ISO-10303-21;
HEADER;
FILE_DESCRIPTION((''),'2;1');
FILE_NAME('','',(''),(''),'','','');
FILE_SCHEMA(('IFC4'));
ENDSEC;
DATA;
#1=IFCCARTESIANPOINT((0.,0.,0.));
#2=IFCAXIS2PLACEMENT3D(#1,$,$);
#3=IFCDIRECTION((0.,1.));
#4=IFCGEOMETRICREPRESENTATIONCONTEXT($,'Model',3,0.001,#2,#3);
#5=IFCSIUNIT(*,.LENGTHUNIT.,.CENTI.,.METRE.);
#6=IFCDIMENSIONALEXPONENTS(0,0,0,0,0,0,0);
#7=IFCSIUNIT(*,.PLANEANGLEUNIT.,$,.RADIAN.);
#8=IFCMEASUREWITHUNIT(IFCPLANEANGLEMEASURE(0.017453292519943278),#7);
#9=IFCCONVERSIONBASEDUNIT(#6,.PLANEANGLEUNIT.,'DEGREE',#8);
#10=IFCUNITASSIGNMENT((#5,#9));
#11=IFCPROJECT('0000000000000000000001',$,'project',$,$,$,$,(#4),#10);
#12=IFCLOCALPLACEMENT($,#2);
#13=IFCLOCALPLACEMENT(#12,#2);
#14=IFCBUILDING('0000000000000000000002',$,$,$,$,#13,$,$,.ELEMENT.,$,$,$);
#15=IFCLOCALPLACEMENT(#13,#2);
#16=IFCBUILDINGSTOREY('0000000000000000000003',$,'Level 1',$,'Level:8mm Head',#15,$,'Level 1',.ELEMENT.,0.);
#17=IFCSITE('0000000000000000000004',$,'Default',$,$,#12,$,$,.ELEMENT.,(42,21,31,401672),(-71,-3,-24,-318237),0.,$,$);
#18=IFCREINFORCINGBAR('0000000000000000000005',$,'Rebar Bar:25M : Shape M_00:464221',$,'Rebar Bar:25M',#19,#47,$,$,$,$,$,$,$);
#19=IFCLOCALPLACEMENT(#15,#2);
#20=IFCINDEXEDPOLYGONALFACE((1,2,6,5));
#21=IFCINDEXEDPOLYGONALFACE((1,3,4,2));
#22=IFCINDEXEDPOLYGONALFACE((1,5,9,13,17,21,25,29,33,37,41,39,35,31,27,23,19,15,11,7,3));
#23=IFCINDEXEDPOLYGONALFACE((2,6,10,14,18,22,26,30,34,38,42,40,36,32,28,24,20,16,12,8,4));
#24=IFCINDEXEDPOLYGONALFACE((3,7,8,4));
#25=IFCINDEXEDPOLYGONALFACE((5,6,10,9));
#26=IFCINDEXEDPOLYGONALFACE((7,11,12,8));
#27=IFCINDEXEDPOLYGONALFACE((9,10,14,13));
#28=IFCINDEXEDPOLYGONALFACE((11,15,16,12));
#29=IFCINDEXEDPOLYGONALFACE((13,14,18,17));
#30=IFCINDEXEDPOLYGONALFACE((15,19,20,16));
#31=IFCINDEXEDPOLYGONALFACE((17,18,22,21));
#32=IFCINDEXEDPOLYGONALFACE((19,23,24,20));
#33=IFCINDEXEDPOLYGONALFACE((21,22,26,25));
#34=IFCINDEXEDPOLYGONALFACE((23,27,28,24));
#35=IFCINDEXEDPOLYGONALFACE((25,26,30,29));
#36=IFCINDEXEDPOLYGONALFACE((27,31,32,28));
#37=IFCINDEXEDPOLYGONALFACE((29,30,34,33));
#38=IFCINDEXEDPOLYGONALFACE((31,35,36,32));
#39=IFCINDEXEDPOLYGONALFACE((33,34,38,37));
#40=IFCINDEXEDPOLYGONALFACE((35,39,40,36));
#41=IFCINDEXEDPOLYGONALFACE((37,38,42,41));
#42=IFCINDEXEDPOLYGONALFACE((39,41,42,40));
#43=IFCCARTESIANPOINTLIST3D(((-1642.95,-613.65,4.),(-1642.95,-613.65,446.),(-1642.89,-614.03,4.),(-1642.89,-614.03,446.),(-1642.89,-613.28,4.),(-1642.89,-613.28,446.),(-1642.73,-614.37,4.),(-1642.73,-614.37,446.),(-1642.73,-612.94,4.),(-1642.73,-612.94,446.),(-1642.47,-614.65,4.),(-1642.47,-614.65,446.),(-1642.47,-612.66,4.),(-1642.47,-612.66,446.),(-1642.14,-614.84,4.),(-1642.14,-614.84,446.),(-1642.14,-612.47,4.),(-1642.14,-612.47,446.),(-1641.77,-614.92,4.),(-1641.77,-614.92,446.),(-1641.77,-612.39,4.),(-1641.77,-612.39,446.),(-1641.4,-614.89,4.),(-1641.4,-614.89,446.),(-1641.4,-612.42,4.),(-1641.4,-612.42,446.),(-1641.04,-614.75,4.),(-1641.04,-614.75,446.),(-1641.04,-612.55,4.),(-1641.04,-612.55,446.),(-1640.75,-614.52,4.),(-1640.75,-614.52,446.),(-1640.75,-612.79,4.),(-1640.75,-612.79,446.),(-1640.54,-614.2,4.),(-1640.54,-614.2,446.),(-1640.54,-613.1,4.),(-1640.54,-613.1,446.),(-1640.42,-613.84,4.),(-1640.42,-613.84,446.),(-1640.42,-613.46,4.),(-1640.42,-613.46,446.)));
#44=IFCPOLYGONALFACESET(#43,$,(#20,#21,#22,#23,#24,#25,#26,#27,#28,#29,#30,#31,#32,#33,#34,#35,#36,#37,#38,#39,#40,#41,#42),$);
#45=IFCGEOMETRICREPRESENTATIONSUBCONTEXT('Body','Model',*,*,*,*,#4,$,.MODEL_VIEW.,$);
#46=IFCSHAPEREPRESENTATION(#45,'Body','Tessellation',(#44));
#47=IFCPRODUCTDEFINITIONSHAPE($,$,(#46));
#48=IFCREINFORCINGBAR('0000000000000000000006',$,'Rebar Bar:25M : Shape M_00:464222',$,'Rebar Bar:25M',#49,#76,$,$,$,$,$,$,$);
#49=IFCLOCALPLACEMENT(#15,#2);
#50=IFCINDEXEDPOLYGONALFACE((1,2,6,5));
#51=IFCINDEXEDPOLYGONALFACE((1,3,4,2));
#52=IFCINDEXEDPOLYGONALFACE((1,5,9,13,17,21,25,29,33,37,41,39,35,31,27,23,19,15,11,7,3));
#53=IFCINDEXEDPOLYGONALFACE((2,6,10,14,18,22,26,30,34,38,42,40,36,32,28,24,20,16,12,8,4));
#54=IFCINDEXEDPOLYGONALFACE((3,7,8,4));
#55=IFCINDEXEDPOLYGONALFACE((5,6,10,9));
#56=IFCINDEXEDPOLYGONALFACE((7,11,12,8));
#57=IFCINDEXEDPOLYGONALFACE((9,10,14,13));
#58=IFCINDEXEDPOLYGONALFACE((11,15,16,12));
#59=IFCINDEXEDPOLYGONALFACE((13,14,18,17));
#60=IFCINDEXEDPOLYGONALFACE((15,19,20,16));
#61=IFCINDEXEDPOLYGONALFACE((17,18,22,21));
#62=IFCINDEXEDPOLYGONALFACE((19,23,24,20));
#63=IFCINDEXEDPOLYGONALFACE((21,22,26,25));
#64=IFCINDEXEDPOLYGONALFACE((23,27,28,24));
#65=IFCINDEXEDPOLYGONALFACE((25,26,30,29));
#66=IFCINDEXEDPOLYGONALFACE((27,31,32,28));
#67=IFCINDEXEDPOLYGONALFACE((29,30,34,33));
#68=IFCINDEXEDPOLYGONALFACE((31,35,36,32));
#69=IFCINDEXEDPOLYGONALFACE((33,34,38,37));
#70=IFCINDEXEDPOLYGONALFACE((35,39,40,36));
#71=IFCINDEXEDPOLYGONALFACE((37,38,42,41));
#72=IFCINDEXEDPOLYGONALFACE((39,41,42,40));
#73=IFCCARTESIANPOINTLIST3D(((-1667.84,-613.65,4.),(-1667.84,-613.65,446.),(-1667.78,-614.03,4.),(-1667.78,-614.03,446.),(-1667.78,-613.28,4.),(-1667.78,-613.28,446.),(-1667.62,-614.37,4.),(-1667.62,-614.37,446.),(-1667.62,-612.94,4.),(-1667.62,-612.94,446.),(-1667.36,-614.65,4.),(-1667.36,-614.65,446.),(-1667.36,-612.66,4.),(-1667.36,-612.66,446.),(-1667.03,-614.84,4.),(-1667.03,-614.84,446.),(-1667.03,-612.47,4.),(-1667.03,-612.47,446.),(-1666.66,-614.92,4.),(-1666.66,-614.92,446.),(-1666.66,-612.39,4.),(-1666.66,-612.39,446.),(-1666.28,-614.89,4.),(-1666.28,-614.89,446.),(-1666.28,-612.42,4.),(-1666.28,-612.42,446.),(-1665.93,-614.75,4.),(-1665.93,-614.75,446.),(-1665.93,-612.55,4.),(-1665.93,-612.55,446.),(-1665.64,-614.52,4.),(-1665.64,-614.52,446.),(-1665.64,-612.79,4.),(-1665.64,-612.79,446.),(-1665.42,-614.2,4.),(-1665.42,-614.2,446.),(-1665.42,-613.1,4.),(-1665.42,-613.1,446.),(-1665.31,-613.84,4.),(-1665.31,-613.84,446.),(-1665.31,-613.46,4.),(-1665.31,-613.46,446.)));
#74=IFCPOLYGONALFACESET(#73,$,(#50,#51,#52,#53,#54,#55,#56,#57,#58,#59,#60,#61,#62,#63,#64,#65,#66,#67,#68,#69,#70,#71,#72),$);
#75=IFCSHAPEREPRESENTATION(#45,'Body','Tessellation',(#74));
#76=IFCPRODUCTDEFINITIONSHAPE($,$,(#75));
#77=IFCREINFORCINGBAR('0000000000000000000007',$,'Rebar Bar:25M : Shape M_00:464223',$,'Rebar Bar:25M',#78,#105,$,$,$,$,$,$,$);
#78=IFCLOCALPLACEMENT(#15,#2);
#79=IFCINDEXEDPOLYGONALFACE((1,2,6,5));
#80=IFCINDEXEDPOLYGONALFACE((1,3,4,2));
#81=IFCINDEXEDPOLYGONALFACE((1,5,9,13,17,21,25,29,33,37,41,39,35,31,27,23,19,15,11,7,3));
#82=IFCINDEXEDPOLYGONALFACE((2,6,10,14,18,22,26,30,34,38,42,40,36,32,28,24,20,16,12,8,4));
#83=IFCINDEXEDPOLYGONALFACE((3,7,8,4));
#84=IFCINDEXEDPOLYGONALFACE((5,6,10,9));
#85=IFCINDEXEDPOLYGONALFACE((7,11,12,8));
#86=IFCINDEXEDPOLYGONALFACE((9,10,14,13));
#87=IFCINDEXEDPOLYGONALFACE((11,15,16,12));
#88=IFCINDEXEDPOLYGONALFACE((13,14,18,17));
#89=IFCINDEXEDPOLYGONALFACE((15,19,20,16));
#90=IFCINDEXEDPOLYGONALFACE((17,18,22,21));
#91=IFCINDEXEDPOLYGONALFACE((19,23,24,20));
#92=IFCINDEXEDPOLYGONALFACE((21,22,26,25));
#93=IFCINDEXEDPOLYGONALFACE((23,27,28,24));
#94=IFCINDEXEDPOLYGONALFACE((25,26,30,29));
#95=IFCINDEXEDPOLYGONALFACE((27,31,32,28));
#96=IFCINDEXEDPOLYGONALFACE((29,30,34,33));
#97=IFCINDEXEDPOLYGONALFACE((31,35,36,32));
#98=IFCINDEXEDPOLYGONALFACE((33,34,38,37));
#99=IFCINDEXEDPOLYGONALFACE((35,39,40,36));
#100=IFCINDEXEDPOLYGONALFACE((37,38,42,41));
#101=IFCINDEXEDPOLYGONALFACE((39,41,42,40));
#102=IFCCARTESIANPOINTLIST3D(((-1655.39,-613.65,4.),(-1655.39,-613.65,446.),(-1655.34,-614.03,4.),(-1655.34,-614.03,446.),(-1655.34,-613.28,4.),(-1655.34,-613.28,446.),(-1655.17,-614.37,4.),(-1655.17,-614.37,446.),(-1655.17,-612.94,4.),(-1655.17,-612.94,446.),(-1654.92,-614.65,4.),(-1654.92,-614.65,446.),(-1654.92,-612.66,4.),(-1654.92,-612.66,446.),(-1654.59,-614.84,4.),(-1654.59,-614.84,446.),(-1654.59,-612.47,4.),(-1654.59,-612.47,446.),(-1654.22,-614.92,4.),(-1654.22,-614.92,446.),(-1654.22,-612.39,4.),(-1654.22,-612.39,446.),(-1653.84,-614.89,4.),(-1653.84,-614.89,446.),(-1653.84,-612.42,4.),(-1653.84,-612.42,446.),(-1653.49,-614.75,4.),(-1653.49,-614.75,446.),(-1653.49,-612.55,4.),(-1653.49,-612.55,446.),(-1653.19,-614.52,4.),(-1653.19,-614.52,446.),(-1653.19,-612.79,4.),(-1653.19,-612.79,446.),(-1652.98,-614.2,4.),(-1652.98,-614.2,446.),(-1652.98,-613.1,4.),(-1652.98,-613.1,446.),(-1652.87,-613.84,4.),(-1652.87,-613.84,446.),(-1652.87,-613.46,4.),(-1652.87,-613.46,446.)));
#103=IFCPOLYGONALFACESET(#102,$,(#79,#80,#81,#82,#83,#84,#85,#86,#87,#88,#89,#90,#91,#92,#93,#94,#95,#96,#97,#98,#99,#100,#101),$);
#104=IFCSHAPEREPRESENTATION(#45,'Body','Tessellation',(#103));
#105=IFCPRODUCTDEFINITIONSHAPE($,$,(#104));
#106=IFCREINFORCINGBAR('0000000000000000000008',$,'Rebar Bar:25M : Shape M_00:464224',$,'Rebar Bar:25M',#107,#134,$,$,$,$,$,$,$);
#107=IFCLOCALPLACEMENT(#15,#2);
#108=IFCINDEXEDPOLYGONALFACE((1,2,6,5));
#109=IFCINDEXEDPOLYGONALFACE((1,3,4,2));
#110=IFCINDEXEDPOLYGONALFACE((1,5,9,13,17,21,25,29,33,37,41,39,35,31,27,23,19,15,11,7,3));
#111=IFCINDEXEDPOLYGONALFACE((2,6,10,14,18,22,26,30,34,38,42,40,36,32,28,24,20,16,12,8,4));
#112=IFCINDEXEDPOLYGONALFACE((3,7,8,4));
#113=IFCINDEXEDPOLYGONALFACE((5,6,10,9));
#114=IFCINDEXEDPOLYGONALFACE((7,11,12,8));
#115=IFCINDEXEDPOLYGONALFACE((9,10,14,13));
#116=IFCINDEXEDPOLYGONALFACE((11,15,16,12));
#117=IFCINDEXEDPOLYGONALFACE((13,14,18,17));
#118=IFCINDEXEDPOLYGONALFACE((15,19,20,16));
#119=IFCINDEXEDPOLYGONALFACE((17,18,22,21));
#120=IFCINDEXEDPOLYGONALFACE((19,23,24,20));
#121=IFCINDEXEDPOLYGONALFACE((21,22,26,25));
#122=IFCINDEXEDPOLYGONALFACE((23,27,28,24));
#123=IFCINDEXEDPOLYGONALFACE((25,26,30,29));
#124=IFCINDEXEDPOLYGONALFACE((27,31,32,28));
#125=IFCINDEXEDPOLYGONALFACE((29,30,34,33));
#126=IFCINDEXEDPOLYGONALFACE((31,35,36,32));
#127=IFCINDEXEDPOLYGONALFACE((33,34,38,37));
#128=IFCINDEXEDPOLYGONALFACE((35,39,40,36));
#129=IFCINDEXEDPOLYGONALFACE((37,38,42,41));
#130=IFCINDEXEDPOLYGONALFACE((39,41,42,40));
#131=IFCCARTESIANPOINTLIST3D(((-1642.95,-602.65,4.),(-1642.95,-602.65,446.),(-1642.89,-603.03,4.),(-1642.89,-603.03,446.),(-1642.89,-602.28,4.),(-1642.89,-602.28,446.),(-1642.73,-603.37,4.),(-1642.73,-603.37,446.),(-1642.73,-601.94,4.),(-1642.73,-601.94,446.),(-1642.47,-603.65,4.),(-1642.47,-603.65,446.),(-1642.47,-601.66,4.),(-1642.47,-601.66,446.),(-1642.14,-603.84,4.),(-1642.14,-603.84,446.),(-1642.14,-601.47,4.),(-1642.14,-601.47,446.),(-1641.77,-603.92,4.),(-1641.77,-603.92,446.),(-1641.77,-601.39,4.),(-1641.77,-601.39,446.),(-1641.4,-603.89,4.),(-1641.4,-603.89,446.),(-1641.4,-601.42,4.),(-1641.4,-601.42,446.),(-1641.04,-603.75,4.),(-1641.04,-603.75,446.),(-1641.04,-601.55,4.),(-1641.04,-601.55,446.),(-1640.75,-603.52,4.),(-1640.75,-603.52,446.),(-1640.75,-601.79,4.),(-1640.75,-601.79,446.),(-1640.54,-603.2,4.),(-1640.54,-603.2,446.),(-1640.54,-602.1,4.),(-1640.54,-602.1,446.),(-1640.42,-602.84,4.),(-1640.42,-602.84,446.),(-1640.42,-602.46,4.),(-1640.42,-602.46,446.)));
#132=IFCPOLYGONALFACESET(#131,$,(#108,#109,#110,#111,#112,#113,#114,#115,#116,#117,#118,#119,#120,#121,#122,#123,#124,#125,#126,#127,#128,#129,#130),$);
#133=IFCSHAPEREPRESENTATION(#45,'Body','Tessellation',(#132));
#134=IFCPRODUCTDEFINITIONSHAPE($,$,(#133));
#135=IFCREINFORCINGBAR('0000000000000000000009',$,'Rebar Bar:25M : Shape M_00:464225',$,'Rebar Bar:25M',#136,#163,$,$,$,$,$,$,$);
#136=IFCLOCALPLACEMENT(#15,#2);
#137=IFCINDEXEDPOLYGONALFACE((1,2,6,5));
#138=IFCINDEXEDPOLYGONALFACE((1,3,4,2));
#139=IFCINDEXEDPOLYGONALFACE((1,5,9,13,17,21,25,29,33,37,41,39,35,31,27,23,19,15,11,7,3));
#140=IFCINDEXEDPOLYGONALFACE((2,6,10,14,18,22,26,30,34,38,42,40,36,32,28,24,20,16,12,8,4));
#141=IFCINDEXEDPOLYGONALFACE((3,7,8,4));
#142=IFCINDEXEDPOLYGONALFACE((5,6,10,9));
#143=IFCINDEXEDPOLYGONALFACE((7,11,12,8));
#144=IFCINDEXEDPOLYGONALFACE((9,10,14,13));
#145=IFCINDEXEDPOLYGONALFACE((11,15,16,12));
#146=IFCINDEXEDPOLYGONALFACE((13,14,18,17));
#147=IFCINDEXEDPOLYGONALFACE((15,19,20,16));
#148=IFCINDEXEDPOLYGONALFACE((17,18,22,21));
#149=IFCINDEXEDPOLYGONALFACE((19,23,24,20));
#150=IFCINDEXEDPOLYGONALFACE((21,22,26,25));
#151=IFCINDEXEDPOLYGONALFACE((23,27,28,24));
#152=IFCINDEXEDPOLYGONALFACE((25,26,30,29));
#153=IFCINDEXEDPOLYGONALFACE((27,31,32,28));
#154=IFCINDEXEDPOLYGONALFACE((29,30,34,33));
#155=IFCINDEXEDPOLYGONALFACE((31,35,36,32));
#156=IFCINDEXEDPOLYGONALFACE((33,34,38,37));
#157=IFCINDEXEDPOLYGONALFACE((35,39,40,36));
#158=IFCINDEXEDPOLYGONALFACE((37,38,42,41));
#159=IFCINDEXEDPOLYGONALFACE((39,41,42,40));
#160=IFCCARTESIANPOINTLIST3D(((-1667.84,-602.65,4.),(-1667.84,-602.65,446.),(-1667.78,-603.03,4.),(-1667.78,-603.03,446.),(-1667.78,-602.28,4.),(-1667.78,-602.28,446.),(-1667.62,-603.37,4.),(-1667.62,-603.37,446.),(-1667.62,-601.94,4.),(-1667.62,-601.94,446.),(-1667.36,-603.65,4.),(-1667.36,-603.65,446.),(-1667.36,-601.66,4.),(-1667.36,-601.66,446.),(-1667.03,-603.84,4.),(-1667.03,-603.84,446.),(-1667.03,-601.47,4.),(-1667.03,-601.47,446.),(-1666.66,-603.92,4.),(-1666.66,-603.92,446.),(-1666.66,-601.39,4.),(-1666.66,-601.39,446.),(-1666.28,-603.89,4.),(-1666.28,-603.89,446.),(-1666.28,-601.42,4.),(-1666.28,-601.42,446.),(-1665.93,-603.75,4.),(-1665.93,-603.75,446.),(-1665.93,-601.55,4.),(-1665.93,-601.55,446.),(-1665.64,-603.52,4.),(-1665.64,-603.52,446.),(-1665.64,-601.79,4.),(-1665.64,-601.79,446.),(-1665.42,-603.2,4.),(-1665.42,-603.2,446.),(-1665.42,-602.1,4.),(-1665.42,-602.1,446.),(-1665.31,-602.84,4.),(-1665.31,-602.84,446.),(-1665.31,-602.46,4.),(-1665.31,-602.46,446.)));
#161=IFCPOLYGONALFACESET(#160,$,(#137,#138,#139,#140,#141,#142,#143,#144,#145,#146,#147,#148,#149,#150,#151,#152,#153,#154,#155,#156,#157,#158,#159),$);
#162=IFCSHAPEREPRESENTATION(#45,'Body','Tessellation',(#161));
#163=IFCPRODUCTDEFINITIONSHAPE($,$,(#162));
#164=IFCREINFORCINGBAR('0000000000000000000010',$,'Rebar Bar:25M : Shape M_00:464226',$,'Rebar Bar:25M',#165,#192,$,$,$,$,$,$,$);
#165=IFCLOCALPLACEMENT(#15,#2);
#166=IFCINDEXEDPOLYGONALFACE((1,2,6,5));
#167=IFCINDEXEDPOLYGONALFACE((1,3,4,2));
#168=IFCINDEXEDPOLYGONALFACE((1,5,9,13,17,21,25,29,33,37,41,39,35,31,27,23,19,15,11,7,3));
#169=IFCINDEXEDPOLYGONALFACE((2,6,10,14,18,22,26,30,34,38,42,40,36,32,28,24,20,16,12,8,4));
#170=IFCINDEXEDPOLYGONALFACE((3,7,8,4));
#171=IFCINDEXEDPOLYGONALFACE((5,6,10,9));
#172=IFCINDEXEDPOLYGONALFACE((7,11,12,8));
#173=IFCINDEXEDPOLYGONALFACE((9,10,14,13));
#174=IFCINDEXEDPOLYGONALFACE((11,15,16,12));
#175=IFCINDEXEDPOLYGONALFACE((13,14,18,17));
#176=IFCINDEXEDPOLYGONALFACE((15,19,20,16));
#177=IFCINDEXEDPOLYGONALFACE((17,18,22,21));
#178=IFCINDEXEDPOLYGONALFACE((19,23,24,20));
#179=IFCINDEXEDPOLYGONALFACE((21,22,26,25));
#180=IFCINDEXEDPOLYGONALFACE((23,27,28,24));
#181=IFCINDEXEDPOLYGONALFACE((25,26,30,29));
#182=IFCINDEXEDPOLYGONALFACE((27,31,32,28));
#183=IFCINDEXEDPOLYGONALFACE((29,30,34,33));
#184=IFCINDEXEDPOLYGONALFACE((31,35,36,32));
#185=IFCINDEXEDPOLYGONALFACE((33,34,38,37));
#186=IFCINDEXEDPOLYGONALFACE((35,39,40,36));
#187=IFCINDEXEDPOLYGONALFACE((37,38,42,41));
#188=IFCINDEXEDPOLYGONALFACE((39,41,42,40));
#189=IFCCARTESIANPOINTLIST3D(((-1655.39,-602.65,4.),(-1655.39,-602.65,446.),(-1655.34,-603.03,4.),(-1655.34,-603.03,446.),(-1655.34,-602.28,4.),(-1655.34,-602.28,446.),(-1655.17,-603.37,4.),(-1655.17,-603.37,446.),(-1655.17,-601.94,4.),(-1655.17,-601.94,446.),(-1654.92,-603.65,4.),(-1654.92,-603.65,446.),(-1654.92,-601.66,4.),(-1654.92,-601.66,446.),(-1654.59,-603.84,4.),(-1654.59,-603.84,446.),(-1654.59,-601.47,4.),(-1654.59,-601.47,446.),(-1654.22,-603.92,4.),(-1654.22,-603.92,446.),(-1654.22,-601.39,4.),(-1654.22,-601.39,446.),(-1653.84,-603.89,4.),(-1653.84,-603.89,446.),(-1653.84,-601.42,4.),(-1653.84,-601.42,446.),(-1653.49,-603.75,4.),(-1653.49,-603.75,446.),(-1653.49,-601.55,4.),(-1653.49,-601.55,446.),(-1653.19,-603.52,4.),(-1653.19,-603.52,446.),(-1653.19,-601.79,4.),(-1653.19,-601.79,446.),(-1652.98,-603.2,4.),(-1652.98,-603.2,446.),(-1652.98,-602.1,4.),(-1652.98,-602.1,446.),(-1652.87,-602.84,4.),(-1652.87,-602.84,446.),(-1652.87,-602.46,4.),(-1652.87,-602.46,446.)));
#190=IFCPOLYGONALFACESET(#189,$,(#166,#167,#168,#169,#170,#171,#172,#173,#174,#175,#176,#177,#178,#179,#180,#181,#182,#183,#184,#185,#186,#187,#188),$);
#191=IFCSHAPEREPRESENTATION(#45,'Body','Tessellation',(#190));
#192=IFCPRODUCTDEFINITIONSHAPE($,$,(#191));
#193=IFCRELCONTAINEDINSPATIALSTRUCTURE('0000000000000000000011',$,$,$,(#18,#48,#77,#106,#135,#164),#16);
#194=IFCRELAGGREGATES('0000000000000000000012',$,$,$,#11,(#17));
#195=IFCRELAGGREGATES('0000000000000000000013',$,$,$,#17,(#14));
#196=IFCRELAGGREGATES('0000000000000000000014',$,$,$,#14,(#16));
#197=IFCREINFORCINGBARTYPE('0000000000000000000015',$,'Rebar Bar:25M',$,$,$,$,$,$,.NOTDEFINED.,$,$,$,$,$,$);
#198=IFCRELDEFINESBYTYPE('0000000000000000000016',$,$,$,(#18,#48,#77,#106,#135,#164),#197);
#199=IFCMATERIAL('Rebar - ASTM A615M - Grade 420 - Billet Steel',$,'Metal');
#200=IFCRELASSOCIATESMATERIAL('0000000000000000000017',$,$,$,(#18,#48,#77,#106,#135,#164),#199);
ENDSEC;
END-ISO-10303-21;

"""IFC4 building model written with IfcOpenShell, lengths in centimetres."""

from ifc_helpers import new_model, entity, si_unit, converted_unit, direction, origin, place, context, subcontext, project, spatial, material, type_object, element, save


model = new_model("IFC4")

# Units and contexts
model_context = context("Model", 3, precision=0.001, world=origin(), true_north=direction((0.0, 1.0)))
body_context = subcontext(model_context, "Body", "Model", "MODEL_VIEW")
ifc_project = project(units=[si_unit("LENGTHUNIT", "METRE", prefix="CENTI"), converted_unit("PLANEANGLEUNIT", "DEGREE", entity("IfcPlaneAngleMeasure", 0.017453292519943278), si_unit("PLANEANGLEUNIT", "RADIAN"), dimensions=[0, 0, 0, 0, 0, 0, 0])], contexts=[model_context])

# Site, building, storey
site_placement = place(None, origin())
site = spatial("IfcSite", under=ifc_project, at=site_placement, Name="Default", CompositionType="ELEMENT", RefLatitude=(42, 21, 31, 401672), RefLongitude=(-71, -3, -24, -318237), RefElevation=0.0)
building_placement = place(site_placement, origin())
building = spatial("IfcBuilding", under=site, at=building_placement, CompositionType="ELEMENT")
storey_placement = place(building_placement, origin())
storey = spatial("IfcBuildingStorey", under=building, at=storey_placement, Name="Level 1", ObjectType="Level:8mm Head", LongName="Level 1", CompositionType="ELEMENT", Elevation=0.0)

# Reinforcing bars
ifc_material = material(Name="Rebar - ASTM A615M - Grade 420 - Billet Steel", Category="Metal")
reinforcing_bar_type_1 = type_object("IfcReinforcingBarType", Name="Rebar Bar:25M", PredefinedType="NOTDEFINED")
reinforcing_bar_1_placement = place(storey_placement, origin())
element("IfcReinforcingBar", 1, at=reinforcing_bar_1_placement, inside=storey, type_object=reinforcing_bar_type_1, material=ifc_material, Name="Rebar Bar:25M : Shape M_00:464221", ObjectType="Rebar Bar:25M", context=body_context, shape_type="AdvancedSweptSolid", body=[
    entity("IfcSweptDiskSolid", entity("IfcIndexedPolyCurve", entity("IfcCartesianPointList3D", [[-1641.68, -613.65, 446.0], [-1641.68, -613.65, 4.0]]), None, False), 1.27, None, 0.0, 1.0),
])
reinforcing_bar_2_placement = place(storey_placement, origin())
element("IfcReinforcingBar", 2, at=reinforcing_bar_2_placement, inside=storey, type_object=reinforcing_bar_type_1, material=ifc_material, Name="Rebar Bar:25M : Shape M_00:464222", ObjectType="Rebar Bar:25M", context=body_context, shape_type="AdvancedSweptSolid", body=[
    entity("IfcSweptDiskSolid", entity("IfcIndexedPolyCurve", entity("IfcCartesianPointList3D", [[-1666.57, -613.65, 446.0], [-1666.57, -613.65, 4.0]]), None, False), 1.27, None, 0.0, 1.0),
])
reinforcing_bar_3_placement = place(storey_placement, origin())
element("IfcReinforcingBar", 3, at=reinforcing_bar_3_placement, inside=storey, type_object=reinforcing_bar_type_1, material=ifc_material, Name="Rebar Bar:25M : Shape M_00:464223", ObjectType="Rebar Bar:25M", context=body_context, shape_type="AdvancedSweptSolid", body=[
    entity("IfcSweptDiskSolid", entity("IfcIndexedPolyCurve", entity("IfcCartesianPointList3D", [[-1654.12, -613.65, 446.0], [-1654.12, -613.65, 4.0]]), None, False), 1.27, None, 0.0, 1.0),
])
reinforcing_bar_4_placement = place(storey_placement, origin())
element("IfcReinforcingBar", 4, at=reinforcing_bar_4_placement, inside=storey, type_object=reinforcing_bar_type_1, material=ifc_material, Name="Rebar Bar:25M : Shape M_00:464224", ObjectType="Rebar Bar:25M", context=body_context, shape_type="AdvancedSweptSolid", body=[
    entity("IfcSweptDiskSolid", entity("IfcIndexedPolyCurve", entity("IfcCartesianPointList3D", [[-1641.68, -602.65, 446.0], [-1641.68, -602.65, 4.0]]), None, False), 1.27, None, 0.0, 1.0),
])
reinforcing_bar_5_placement = place(storey_placement, origin())
element("IfcReinforcingBar", 5, at=reinforcing_bar_5_placement, inside=storey, type_object=reinforcing_bar_type_1, material=ifc_material, Name="Rebar Bar:25M : Shape M_00:464225", ObjectType="Rebar Bar:25M", context=body_context, shape_type="AdvancedSweptSolid", body=[
    entity("IfcSweptDiskSolid", entity("IfcIndexedPolyCurve", entity("IfcCartesianPointList3D", [[-1666.57, -602.65, 446.0], [-1666.57, -602.65, 4.0]]), None, False), 1.27, None, 0.0, 1.0),
])
reinforcing_bar_6_placement = place(storey_placement, origin())
element("IfcReinforcingBar", 6, at=reinforcing_bar_6_placement, inside=storey, type_object=reinforcing_bar_type_1, material=ifc_material, Name="Rebar Bar:25M : Shape M_00:464226", ObjectType="Rebar Bar:25M", context=body_context, shape_type="AdvancedSweptSolid", body=[
    entity("IfcSweptDiskSolid", entity("IfcIndexedPolyCurve", entity("IfcCartesianPointList3D", [[-1654.12, -602.65, 446.0], [-1654.12, -602.65, 4.0]]), None, False), 1.27, None, 0.0, 1.0),
])

save(model, "model.ifc")
